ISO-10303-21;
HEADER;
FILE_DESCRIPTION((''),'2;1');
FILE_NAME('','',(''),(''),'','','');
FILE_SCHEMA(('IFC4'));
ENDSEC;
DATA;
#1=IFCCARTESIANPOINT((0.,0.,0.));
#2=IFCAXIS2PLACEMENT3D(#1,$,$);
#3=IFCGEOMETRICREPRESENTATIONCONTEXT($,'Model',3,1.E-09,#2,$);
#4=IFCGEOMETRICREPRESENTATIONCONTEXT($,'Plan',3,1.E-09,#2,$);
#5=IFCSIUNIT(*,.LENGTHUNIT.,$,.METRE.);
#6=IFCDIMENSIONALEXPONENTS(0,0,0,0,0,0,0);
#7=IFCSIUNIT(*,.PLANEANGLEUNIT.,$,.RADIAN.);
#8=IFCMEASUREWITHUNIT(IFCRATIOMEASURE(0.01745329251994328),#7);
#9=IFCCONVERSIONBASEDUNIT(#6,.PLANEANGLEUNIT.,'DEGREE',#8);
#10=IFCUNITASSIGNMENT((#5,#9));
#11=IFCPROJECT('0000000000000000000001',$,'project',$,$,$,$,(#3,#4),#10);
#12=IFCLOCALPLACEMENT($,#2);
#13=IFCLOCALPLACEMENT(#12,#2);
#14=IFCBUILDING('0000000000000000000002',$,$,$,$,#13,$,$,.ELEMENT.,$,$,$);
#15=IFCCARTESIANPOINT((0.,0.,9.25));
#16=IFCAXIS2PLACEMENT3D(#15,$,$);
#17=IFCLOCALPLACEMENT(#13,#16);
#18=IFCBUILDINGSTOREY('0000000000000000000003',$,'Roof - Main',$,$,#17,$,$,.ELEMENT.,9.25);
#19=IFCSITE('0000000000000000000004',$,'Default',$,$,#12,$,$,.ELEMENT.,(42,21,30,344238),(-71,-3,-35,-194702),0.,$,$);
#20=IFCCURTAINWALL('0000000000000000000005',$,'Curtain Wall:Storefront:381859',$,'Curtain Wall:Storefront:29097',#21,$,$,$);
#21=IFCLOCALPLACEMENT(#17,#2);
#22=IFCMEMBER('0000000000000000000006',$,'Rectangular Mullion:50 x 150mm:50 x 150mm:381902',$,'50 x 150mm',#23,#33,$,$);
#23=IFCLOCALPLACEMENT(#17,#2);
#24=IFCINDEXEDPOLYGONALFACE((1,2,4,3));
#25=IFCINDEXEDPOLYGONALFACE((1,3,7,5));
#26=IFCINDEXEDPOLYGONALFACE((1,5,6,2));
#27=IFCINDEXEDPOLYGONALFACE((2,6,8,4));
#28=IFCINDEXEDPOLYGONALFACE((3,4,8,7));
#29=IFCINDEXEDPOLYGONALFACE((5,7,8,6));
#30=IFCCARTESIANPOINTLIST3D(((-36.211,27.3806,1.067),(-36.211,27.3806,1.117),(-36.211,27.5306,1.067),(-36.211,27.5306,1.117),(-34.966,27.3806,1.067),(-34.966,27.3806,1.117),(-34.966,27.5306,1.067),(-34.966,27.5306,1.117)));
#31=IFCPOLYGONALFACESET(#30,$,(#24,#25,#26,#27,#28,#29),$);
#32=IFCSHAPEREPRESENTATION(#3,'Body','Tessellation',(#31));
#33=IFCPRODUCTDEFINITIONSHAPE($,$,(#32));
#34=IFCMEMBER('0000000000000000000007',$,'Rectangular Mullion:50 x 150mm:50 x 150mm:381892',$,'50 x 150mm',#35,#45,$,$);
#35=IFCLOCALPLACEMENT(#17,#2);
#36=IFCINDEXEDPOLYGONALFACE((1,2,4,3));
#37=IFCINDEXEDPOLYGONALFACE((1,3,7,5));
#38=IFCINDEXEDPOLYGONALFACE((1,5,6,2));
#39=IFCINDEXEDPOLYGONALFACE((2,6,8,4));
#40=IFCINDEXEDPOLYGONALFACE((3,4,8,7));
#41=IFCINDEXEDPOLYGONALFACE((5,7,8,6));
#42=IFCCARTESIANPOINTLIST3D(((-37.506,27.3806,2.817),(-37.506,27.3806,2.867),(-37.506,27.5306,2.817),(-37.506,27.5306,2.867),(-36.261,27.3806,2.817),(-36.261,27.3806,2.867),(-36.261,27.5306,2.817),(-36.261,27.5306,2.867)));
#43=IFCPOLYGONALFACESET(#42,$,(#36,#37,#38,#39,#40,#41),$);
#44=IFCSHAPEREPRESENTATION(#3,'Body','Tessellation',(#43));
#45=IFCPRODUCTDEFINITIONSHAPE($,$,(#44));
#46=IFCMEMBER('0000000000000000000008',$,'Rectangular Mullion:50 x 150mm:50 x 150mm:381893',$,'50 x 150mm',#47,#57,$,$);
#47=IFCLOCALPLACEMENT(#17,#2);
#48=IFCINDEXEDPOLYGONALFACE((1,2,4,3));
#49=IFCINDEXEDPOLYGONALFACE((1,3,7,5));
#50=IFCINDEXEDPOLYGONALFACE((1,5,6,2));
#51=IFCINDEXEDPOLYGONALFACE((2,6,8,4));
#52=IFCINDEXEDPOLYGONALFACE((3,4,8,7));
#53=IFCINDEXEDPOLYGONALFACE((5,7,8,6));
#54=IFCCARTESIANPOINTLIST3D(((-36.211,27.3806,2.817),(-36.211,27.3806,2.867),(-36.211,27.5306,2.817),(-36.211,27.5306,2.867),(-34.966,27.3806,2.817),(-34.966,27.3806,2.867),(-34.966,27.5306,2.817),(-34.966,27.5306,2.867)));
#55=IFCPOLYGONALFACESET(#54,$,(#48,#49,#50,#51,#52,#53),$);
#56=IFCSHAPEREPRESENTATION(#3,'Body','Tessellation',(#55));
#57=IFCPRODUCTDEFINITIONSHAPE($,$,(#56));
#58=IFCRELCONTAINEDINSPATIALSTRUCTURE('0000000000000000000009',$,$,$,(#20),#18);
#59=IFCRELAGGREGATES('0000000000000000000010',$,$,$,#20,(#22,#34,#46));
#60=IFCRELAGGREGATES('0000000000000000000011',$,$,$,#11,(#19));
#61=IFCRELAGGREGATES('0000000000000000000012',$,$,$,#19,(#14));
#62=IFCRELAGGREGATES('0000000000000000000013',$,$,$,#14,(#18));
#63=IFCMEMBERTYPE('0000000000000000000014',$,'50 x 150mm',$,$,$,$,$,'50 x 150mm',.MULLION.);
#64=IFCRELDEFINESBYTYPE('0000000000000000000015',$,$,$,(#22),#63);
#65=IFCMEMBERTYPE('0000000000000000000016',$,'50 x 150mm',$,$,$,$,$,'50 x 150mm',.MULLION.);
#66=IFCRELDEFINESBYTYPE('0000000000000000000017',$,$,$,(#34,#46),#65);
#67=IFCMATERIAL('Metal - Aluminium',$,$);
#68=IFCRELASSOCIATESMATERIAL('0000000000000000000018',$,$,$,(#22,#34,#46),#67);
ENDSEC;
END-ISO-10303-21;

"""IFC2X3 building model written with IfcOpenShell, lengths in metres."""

from ifc_helpers import new_model, entity, si_unit, converted_unit, frame, origin, origin_2d_with_axis, place, context, project, spatial, rectangle, extrude, source, transform, mapped, material, type_object, type_shapes, element, aggregate, save


model = new_model("IFC2X3")

# Units and contexts
model_context = context("Model", 3, precision=1e-09, world=origin())
plan_context = context("Plan", 3, precision=1e-09, world=origin())
ifc_project = project(units=[si_unit("LENGTHUNIT", "METRE"), converted_unit("PLANEANGLEUNIT", "DEGREE", entity("IfcRatioMeasure", 0.01745329251994328), si_unit("PLANEANGLEUNIT", "RADIAN"), dimensions=[0, 0, 0, 0, 0, 0, 0])], contexts=[model_context, plan_context])

# Site, building, storey
site_placement = place(None, origin())
site = spatial("IfcSite", under=ifc_project, at=site_placement, Name="Default", CompositionType="ELEMENT", RefLatitude=(42, 21, 30, 344238), RefLongitude=(-71, -3, -35, -194702), RefElevation=0.0)
building_placement = place(site_placement, origin())
building = spatial("IfcBuilding", under=site, at=building_placement, CompositionType="ELEMENT")
storey_placement = place(building_placement, frame((0.0, 0.0, 9.25)))
storey = spatial("IfcBuildingStorey", under=building, at=storey_placement, Name="Roof - Main", CompositionType="ELEMENT", Elevation=9.25)

# Curtain wall, members
curtain_wall_placement = place(storey_placement, origin())
curtain_wall = element("IfcCurtainWall", 1, at=curtain_wall_placement, inside=storey, Name="Curtain Wall:Storefront:381859", ObjectType="Curtain Wall:Storefront:29097")
ifc_material_1 = material(Name="Metal - Aluminium")
member_type_1 = type_object("IfcMemberType", Name="50 x 150mm", ElementType="50 x 150mm", PredefinedType="MULLION")
shared_shape_1 = source(origin(), model_context, "Body", "SweptSolid", [
    extrude(rectangle(XDim=0.05, YDim=0.15, at=origin_2d_with_axis()), frame((-0.025, 0.0, -1.245), z_axis=(0.0, 0.0, 1.0), x_axis=(-1.0, 0.0, 0.0)), (0.0, 0.0, 1.0), 1.245),
])
type_shapes(member_type_1, [shared_shape_1])
member_1_placement = place(storey_placement, frame((-36.211, 27.4556, 1.067), z_axis=(-1.0, 0.0, 0.0), x_axis=(0.0, 0.0, -1.0)))
member_1 = element("IfcMember", 2, at=member_1_placement, type_object=member_type_1, material=ifc_material_1, Name="Rectangular Mullion:50 x 150mm:50 x 150mm:381902", ObjectType="50 x 150mm", context=model_context, shape_type="MappedRepresentation", body=[
    mapped(shared_shape_1, transform((0.0, 0.0, 0.0), scale=1.0)),
])
member_type_2 = type_object("IfcMemberType", Name="50 x 150mm", ElementType="50 x 150mm", PredefinedType="MULLION")
shared_shape_2 = source(origin(), model_context, "Body", "SweptSolid", [
    extrude(rectangle(XDim=0.05, YDim=0.15, at=origin_2d_with_axis()), frame((-0.025, 0.0, -1.245), z_axis=(0.0, 0.0, 1.0), x_axis=(-1.0, 0.0, 0.0)), (0.0, 0.0, 1.0), 1.245),
])
type_shapes(member_type_2, [shared_shape_2])
member_2_placement = place(storey_placement, frame((-36.261, 27.4556, 2.867), z_axis=(1.0, 0.0, 0.0), x_axis=(0.0, 0.0, 1.0)))
member_2 = element("IfcMember", 3, at=member_2_placement, type_object=member_type_2, material=ifc_material_1, Name="Rectangular Mullion:50 x 150mm:50 x 150mm:381892", ObjectType="50 x 150mm", context=model_context, shape_type="MappedRepresentation", body=[
    mapped(shared_shape_2, transform((0.0, 0.0, 0.0), scale=1.0)),
])
member_3_placement = place(storey_placement, frame((-34.966, 27.4556, 2.867), z_axis=(1.0, 0.0, 0.0), x_axis=(0.0, 0.0, 1.0)))
member_3 = element("IfcMember", 4, at=member_3_placement, type_object=member_type_2, material=ifc_material_1, Name="Rectangular Mullion:50 x 150mm:50 x 150mm:381893", ObjectType="50 x 150mm", context=model_context, shape_type="MappedRepresentation", body=[
    mapped(shared_shape_2, transform((0.0, 0.0, 0.0), scale=1.0)),
])
aggregate(curtain_wall, [member_1, member_2, member_3])

save(model, "model.ifc")
